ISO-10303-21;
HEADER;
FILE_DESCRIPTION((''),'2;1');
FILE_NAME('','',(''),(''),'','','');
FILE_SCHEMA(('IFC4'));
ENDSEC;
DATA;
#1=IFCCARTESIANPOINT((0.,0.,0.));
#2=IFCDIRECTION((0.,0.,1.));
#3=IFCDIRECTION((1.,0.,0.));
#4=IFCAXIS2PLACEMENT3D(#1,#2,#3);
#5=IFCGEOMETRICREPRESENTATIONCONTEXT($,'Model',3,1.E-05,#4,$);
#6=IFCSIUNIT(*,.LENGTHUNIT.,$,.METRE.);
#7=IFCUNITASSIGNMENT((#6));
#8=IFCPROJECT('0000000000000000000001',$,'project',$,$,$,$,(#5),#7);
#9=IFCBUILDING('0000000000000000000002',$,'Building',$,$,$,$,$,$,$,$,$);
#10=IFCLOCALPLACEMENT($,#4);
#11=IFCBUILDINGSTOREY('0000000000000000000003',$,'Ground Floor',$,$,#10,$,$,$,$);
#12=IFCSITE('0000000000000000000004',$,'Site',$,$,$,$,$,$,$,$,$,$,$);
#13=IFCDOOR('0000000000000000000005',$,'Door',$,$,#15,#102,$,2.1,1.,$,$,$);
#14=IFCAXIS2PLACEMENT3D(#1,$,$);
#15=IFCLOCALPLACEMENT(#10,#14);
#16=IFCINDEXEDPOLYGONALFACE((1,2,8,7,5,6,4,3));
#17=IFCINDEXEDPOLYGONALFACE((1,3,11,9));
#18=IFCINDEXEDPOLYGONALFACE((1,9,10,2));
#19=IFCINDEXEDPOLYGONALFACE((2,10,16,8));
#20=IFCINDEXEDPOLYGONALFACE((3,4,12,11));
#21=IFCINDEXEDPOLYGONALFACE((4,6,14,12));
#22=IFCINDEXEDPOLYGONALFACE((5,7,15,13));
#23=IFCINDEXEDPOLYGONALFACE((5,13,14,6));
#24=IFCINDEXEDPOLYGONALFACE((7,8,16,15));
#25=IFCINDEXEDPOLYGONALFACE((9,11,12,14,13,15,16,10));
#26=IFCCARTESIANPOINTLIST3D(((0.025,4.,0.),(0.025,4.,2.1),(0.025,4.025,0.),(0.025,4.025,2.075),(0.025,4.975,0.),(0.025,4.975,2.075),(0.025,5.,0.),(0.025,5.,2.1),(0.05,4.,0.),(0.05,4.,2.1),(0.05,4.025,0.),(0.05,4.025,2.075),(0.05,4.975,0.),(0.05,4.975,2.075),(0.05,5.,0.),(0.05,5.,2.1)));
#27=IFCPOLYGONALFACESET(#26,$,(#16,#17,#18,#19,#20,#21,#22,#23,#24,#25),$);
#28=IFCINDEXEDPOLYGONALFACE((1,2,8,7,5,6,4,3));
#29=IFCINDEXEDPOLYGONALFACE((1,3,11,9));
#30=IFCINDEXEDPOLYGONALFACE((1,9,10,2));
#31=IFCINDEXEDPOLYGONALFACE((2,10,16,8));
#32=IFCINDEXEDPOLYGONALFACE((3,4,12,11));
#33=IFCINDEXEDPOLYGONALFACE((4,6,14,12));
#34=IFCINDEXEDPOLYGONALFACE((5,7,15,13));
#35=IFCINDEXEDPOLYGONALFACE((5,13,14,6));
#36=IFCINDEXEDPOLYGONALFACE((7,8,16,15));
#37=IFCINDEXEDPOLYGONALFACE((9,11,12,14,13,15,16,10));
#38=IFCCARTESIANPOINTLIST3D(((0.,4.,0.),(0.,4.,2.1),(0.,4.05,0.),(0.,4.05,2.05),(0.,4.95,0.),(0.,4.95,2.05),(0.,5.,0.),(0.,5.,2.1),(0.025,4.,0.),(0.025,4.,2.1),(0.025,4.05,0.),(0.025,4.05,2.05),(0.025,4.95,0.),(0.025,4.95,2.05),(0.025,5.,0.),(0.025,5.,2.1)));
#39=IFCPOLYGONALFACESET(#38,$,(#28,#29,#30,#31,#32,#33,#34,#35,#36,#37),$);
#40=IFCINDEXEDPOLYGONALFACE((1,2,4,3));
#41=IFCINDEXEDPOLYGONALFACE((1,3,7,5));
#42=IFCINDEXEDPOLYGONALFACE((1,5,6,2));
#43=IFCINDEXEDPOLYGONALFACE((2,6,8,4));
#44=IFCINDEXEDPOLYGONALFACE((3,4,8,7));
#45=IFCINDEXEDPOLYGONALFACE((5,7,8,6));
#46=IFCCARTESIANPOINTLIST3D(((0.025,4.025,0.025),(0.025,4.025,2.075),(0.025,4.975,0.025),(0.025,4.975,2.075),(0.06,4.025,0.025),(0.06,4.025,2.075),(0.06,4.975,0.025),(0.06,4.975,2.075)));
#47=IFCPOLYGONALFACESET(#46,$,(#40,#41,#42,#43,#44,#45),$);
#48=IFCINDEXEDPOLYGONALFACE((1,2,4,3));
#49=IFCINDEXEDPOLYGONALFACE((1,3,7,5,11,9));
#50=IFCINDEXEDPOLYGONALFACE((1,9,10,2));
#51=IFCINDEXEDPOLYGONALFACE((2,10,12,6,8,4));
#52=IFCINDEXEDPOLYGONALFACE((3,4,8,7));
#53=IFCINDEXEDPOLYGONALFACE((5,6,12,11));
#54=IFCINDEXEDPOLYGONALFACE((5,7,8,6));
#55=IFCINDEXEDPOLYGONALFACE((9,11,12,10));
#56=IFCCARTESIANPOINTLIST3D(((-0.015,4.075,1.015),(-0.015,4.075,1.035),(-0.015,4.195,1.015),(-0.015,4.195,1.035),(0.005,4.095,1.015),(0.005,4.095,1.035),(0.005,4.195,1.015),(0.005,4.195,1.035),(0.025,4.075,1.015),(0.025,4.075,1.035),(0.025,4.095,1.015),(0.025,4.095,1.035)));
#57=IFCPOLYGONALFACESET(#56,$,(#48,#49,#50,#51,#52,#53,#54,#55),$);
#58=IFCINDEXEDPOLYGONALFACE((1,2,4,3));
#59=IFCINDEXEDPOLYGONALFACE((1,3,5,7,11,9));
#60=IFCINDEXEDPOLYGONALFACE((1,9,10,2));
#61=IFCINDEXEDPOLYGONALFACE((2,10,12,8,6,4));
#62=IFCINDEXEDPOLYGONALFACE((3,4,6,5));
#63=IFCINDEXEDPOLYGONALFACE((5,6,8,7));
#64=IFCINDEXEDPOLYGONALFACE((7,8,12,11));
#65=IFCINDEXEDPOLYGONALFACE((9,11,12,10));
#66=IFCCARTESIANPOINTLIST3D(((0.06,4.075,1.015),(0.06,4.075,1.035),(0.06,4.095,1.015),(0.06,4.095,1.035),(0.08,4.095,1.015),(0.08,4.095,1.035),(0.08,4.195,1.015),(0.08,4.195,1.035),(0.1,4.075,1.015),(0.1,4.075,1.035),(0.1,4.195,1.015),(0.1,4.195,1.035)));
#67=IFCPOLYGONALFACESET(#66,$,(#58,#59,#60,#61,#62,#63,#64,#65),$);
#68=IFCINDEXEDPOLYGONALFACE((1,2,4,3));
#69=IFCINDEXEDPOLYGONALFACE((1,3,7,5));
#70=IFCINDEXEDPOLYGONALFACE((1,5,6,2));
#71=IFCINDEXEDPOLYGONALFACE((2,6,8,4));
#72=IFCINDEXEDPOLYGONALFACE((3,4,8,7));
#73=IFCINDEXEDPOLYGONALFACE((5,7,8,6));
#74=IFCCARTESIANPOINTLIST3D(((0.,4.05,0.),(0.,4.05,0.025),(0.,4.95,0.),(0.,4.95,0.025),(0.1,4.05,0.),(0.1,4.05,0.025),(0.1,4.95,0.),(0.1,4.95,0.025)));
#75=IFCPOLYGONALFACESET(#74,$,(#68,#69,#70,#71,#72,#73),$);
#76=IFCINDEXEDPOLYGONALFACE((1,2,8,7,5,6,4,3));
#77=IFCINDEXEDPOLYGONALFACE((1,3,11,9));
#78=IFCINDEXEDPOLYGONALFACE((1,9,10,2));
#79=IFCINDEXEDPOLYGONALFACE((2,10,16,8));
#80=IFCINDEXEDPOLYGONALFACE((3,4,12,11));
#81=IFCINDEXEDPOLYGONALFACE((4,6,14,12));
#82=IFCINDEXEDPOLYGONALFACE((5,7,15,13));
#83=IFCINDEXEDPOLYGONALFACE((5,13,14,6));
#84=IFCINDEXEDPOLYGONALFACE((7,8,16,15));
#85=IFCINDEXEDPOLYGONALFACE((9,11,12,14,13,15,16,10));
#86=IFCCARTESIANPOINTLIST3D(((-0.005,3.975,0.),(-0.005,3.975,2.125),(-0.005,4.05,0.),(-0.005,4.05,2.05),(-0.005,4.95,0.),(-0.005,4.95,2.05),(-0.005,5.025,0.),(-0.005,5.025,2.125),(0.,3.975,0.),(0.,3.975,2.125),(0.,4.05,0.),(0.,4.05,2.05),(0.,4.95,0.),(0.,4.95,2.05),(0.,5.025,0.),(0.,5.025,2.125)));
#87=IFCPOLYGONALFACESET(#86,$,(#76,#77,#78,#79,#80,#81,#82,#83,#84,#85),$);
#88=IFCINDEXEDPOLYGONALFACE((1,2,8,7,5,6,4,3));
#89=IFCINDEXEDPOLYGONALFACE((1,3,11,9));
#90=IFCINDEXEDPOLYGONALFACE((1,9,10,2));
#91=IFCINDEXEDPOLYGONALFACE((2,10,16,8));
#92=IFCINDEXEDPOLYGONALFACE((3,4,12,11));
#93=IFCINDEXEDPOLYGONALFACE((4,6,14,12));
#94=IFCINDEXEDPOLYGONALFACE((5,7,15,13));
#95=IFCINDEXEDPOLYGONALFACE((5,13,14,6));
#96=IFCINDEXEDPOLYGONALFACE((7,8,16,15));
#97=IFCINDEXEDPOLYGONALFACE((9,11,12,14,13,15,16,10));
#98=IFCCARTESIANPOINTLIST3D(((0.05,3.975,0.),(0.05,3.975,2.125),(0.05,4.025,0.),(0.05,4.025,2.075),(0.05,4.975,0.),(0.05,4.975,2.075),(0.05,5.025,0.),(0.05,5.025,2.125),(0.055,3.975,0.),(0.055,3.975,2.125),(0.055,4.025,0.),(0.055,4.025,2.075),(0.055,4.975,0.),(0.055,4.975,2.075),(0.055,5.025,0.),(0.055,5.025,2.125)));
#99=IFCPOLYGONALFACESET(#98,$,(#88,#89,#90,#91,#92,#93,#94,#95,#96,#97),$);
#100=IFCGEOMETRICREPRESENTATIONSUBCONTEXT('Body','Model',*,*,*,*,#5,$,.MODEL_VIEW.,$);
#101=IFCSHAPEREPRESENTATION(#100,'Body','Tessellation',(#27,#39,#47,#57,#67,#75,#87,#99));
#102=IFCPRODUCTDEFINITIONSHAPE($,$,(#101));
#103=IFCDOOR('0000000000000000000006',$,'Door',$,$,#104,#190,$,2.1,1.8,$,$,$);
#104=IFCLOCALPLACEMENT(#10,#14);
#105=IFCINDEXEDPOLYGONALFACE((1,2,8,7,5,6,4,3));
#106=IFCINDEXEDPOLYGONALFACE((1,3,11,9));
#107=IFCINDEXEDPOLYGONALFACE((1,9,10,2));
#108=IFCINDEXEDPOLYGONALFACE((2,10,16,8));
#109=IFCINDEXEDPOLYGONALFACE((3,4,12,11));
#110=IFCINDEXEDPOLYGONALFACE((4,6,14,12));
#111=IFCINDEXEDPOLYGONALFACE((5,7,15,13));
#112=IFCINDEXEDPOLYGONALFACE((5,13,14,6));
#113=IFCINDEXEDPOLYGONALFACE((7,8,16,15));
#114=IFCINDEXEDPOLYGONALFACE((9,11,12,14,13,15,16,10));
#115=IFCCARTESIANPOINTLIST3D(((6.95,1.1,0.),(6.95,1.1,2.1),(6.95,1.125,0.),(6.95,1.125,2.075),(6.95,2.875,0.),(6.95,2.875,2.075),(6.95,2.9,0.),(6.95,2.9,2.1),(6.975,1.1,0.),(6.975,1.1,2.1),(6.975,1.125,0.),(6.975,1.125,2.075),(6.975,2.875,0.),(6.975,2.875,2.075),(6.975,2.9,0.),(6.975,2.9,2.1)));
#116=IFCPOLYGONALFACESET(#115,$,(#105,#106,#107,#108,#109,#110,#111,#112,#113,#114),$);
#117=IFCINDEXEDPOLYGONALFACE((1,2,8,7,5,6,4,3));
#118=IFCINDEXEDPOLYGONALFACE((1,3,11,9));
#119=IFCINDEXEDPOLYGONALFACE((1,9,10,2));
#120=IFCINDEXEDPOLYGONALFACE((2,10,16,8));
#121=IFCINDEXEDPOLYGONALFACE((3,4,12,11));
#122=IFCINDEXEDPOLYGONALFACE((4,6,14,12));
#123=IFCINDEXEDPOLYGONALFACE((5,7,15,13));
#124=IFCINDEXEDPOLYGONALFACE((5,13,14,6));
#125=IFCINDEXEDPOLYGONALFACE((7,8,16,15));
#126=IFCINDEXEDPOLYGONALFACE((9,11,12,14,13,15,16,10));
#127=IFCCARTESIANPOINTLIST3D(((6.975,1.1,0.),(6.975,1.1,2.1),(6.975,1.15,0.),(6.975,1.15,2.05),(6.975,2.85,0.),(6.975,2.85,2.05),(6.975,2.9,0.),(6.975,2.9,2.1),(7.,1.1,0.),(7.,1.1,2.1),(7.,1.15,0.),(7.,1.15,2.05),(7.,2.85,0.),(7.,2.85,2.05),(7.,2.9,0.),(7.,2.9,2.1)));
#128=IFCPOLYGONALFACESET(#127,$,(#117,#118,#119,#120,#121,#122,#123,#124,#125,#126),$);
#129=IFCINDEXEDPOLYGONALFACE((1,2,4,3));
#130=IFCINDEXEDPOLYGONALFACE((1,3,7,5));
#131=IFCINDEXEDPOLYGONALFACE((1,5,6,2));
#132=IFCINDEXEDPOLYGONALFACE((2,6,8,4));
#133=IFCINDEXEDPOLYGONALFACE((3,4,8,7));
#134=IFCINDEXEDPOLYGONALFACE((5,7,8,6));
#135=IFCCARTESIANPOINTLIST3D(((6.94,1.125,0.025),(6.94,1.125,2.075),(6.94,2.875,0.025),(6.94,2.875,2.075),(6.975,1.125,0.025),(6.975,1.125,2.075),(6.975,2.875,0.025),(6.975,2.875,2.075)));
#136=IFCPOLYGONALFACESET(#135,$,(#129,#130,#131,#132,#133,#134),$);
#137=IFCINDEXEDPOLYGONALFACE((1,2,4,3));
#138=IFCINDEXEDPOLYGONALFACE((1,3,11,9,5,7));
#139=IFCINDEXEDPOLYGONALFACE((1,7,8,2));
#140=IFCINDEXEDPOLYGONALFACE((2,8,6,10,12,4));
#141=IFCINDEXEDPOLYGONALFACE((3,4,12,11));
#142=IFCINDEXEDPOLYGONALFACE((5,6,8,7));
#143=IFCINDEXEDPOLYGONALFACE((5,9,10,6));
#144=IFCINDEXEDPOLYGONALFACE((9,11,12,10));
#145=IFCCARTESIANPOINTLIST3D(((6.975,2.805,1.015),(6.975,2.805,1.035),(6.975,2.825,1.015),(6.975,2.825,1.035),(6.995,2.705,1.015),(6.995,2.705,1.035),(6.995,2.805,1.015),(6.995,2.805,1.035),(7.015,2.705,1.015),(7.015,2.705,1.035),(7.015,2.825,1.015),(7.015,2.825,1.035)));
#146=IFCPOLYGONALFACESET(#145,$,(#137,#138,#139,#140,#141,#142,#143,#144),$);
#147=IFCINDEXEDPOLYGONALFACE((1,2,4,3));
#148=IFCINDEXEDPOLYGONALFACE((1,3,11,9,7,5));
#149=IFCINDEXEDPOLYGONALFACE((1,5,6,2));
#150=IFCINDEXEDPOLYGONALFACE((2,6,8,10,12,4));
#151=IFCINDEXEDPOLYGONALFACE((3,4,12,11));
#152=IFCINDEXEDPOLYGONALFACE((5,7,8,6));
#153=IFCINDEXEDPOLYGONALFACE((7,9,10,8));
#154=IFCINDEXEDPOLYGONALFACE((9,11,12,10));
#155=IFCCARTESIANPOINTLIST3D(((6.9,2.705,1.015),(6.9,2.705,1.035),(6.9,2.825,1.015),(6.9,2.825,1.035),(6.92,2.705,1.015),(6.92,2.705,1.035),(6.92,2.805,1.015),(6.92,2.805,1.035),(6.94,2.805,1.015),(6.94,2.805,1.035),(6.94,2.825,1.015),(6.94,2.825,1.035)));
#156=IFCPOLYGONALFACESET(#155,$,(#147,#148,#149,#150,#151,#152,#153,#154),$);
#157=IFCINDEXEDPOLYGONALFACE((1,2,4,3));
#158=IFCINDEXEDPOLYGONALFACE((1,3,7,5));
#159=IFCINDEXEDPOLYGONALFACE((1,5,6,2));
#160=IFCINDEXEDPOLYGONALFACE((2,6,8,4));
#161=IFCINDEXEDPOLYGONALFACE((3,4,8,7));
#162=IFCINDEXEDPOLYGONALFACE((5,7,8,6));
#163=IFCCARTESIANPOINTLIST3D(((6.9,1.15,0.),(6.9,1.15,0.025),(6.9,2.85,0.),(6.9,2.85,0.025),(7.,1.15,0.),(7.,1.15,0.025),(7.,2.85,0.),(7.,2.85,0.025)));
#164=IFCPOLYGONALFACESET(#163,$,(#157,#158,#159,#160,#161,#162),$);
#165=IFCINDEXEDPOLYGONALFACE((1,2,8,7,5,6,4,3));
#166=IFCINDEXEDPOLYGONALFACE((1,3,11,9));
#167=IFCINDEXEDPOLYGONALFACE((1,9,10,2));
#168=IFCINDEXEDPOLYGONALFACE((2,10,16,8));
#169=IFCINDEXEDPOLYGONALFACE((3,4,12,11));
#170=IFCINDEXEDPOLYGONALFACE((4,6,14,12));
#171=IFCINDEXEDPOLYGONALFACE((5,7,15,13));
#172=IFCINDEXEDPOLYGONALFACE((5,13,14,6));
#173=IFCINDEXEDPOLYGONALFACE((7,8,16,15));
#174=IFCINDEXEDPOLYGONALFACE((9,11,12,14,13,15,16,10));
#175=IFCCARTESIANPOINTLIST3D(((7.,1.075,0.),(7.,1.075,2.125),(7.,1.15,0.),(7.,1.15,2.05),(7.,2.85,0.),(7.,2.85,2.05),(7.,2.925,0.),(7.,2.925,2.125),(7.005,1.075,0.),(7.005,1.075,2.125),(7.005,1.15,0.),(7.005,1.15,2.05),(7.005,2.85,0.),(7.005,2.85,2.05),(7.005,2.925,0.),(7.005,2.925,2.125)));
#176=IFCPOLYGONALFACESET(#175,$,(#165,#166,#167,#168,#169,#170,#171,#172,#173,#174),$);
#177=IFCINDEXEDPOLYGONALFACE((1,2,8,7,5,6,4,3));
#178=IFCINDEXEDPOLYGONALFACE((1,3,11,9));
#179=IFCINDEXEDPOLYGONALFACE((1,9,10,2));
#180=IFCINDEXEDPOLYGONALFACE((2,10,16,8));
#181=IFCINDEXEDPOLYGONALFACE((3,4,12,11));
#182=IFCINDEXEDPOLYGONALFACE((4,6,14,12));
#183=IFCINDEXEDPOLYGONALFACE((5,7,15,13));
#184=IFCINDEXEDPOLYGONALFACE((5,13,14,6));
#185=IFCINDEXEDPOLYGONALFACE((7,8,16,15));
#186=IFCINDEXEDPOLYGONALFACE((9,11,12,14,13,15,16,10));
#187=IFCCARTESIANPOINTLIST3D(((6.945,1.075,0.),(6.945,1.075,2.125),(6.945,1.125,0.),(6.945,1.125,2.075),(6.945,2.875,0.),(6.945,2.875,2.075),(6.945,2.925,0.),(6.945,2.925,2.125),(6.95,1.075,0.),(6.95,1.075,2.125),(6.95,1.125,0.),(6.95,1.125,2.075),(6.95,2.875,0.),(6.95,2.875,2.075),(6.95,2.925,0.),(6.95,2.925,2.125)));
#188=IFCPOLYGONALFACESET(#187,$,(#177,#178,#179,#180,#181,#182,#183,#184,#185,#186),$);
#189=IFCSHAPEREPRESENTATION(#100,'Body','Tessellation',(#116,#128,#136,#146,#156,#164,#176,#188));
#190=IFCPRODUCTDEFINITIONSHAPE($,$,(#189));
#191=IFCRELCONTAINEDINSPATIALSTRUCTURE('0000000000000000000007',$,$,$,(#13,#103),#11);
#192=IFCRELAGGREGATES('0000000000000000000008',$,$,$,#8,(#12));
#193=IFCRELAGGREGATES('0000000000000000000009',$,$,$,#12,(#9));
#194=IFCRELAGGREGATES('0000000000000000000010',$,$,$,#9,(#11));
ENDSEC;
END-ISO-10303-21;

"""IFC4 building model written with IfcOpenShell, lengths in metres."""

from ifc_helpers import new_model, si_unit, frame, origin_with_axes, place, context, subcontext, project, spatial, line, indexed_curve, outline, extrude, element, save


model = new_model("IFC4")

# Units and contexts
model_context = context("Model", 3, precision=1e-05, world=origin_with_axes())
body_context = subcontext(model_context, "Body", "Model", "MODEL_VIEW")
ifc_project = project(units=[si_unit("LENGTHUNIT", "METRE")], contexts=[model_context])

# Site, building, storey
site = spatial("IfcSite", under=ifc_project, Name="Site")
building = spatial("IfcBuilding", under=site, Name="Building")
storey_placement = place(None, origin_with_axes())
storey = spatial("IfcBuildingStorey", under=building, at=storey_placement, Name="Ground Floor")

# Doors
door_1_placement = place(storey_placement, frame((0.0, 5.0, 0.0), z_axis=(0.0, 0.0, 1.0), x_axis=(0.0, -1.0, 0.0)))
element("IfcDoor", 1, at=door_1_placement, inside=storey, Name="Door", OverallHeight=2.1, OverallWidth=1.0, context=body_context, shape_type="SweptSolid", body=[
    extrude(outline(indexed_curve([(0.0, 0.0), (0.0, 2.1), (1.0, 2.1), (1.0, 0.0), (0.975, 0.0), (0.975, 2.075), (0.025, 2.075), (0.025, 0.0)], segments=[line(1, 2, 3, 4, 5, 6, 7, 8, 1)])), frame((0.0, 0.025, 0.0), z_axis=(0.0, -1.0, 0.0), x_axis=(1.0, 0.0, 0.0)), (0.0, 0.0, -1.0), 0.025),
    extrude(outline(indexed_curve([(0.0, 0.0), (0.0, 2.1), (1.0, 2.1), (1.0, 0.0), (0.95, 0.0), (0.95, 2.05), (0.05, 2.05), (0.05, 0.0)], segments=[line(1, 2, 3, 4, 5, 6, 7, 8, 1)])), frame((0.0, 0.0, 0.0), z_axis=(0.0, -1.0, 0.0), x_axis=(1.0, 0.0, 0.0)), (0.0, 0.0, -1.0), 0.025),
    extrude(outline(indexed_curve([(0.0, 0.0), (0.95, 0.0), (0.95, 0.035), (0.0, 0.035)], segments=[line(1, 2, 3, 4, 1)])), frame((0.025, 0.025, 0.025), z_axis=(0.0, 0.0, 1.0), x_axis=(1.0, 0.0, 0.0)), (0.0, 0.0, 1.0), 2.05),
    extrude(outline(indexed_curve([(0.0, 0.0), (0.0, -0.04), (-0.12, -0.04), (-0.12, -0.02), (-0.02, -0.02), (-0.02, 0.0)], segments=[line(1, 2, 3, 4, 5, 6, 1)])), frame((0.925, 0.025, 1.015), z_axis=(0.0, 0.0, 1.0), x_axis=(1.0, 0.0, 0.0)), (0.0, 0.0, 1.0), 0.02),
    extrude(outline(indexed_curve([(0.0, 0.0), (0.0, 0.04), (-0.12, 0.04), (-0.12, 0.02), (-0.02, 0.02), (-0.02, 0.0)], segments=[line(1, 2, 3, 4, 5, 6, 1)])), frame((0.925, 0.06, 1.015), z_axis=(0.0, 0.0, 1.0), x_axis=(1.0, 0.0, 0.0)), (0.0, 0.0, 1.0), 0.02),
    extrude(outline(indexed_curve([(0.0, 0.0), (0.9, 0.0), (0.9, 0.1), (0.0, 0.1)], segments=[line(1, 2, 3, 4, 1)])), frame((0.05, 0.0, 0.0), z_axis=(0.0, 0.0, 1.0), x_axis=(1.0, 0.0, 0.0)), (0.0, 0.0, 1.0), 0.025),
    extrude(outline(indexed_curve([(0.0, 0.0), (0.0, 2.125), (1.05, 2.125), (1.05, 0.0), (0.975, 0.0), (0.975, 2.05), (0.075, 2.05), (0.075, 0.0)], segments=[line(1, 2, 3, 4, 5, 6, 7, 8, 1)])), frame((-0.025, -0.005, 0.0), z_axis=(0.0, -1.0, 0.0), x_axis=(1.0, 0.0, 0.0)), (0.0, 0.0, -1.0), 0.005),
    extrude(outline(indexed_curve([(0.0, 0.0), (0.0, 2.125), (1.05, 2.125), (1.05, 0.0), (1.0, 0.0), (1.0, 2.075), (0.05, 2.075), (0.05, 0.0)], segments=[line(1, 2, 3, 4, 5, 6, 7, 8, 1)])), frame((-0.025, 0.05, 0.0), z_axis=(0.0, -1.0, 0.0), x_axis=(1.0, 0.0, 0.0)), (0.0, 0.0, -1.0), 0.005),
])
door_2_placement = place(storey_placement, frame((7.0, 1.1, 0.0), z_axis=(0.0, 0.0, 1.0), x_axis=(0.0, 1.0, 0.0)))
element("IfcDoor", 2, at=door_2_placement, inside=storey, Name="Door", OverallHeight=2.1, OverallWidth=1.8, context=body_context, shape_type="SweptSolid", body=[
    extrude(outline(indexed_curve([(0.0, 0.0), (0.0, 2.1), (1.8, 2.1), (1.8, 0.0), (1.775, 0.0), (1.775, 2.075), (0.025, 2.075), (0.025, 0.0)], segments=[line(1, 2, 3, 4, 5, 6, 7, 8, 1)])), frame((0.0, 0.025, 0.0), z_axis=(0.0, -1.0, 0.0), x_axis=(1.0, 0.0, 0.0)), (0.0, 0.0, -1.0), 0.025),
    extrude(outline(indexed_curve([(0.0, 0.0), (0.0, 2.1), (1.8, 2.1), (1.8, 0.0), (1.75, 0.0), (1.75, 2.05), (0.05, 2.05), (0.05, 0.0)], segments=[line(1, 2, 3, 4, 5, 6, 7, 8, 1)])), frame((0.0, 0.0, 0.0), z_axis=(0.0, -1.0, 0.0), x_axis=(1.0, 0.0, 0.0)), (0.0, 0.0, -1.0), 0.025),
    extrude(outline(indexed_curve([(0.0, 0.0), (1.75, 0.0), (1.75, 0.035), (0.0, 0.035)], segments=[line(1, 2, 3, 4, 1)])), frame((0.025, 0.025, 0.025), z_axis=(0.0, 0.0, 1.0), x_axis=(1.0, 0.0, 0.0)), (0.0, 0.0, 1.0), 2.05),
    extrude(outline(indexed_curve([(0.0, 0.0), (0.0, -0.04), (-0.12, -0.04), (-0.12, -0.02), (-0.02, -0.02), (-0.02, 0.0)], segments=[line(1, 2, 3, 4, 5, 6, 1)])), frame((1.725, 0.025, 1.015), z_axis=(0.0, 0.0, 1.0), x_axis=(1.0, 0.0, 0.0)), (0.0, 0.0, 1.0), 0.02),
    extrude(outline(indexed_curve([(0.0, 0.0), (0.0, 0.04), (-0.12, 0.04), (-0.12, 0.02), (-0.02, 0.02), (-0.02, 0.0)], segments=[line(1, 2, 3, 4, 5, 6, 1)])), frame((1.725, 0.06, 1.015), z_axis=(0.0, 0.0, 1.0), x_axis=(1.0, 0.0, 0.0)), (0.0, 0.0, 1.0), 0.02),
    extrude(outline(indexed_curve([(0.0, 0.0), (1.7, 0.0), (1.7, 0.1), (0.0, 0.1)], segments=[line(1, 2, 3, 4, 1)])), frame((0.05, 0.0, 0.0), z_axis=(0.0, 0.0, 1.0), x_axis=(1.0, 0.0, 0.0)), (0.0, 0.0, 1.0), 0.025),
    extrude(outline(indexed_curve([(0.0, 0.0), (0.0, 2.125), (1.85, 2.125), (1.85, 0.0), (1.775, 0.0), (1.775, 2.05), (0.075, 2.05), (0.075, 0.0)], segments=[line(1, 2, 3, 4, 5, 6, 7, 8, 1)])), frame((-0.025, -0.005, 0.0), z_axis=(0.0, -1.0, 0.0), x_axis=(1.0, 0.0, 0.0)), (0.0, 0.0, -1.0), 0.005),
    extrude(outline(indexed_curve([(0.0, 0.0), (0.0, 2.125), (1.85, 2.125), (1.85, 0.0), (1.8, 0.0), (1.8, 2.075), (0.05, 2.075), (0.05, 0.0)], segments=[line(1, 2, 3, 4, 5, 6, 7, 8, 1)])), frame((-0.025, 0.05, 0.0), z_axis=(0.0, -1.0, 0.0), x_axis=(1.0, 0.0, 0.0)), (0.0, 0.0, -1.0), 0.005),
])

save(model, "model.ifc")
